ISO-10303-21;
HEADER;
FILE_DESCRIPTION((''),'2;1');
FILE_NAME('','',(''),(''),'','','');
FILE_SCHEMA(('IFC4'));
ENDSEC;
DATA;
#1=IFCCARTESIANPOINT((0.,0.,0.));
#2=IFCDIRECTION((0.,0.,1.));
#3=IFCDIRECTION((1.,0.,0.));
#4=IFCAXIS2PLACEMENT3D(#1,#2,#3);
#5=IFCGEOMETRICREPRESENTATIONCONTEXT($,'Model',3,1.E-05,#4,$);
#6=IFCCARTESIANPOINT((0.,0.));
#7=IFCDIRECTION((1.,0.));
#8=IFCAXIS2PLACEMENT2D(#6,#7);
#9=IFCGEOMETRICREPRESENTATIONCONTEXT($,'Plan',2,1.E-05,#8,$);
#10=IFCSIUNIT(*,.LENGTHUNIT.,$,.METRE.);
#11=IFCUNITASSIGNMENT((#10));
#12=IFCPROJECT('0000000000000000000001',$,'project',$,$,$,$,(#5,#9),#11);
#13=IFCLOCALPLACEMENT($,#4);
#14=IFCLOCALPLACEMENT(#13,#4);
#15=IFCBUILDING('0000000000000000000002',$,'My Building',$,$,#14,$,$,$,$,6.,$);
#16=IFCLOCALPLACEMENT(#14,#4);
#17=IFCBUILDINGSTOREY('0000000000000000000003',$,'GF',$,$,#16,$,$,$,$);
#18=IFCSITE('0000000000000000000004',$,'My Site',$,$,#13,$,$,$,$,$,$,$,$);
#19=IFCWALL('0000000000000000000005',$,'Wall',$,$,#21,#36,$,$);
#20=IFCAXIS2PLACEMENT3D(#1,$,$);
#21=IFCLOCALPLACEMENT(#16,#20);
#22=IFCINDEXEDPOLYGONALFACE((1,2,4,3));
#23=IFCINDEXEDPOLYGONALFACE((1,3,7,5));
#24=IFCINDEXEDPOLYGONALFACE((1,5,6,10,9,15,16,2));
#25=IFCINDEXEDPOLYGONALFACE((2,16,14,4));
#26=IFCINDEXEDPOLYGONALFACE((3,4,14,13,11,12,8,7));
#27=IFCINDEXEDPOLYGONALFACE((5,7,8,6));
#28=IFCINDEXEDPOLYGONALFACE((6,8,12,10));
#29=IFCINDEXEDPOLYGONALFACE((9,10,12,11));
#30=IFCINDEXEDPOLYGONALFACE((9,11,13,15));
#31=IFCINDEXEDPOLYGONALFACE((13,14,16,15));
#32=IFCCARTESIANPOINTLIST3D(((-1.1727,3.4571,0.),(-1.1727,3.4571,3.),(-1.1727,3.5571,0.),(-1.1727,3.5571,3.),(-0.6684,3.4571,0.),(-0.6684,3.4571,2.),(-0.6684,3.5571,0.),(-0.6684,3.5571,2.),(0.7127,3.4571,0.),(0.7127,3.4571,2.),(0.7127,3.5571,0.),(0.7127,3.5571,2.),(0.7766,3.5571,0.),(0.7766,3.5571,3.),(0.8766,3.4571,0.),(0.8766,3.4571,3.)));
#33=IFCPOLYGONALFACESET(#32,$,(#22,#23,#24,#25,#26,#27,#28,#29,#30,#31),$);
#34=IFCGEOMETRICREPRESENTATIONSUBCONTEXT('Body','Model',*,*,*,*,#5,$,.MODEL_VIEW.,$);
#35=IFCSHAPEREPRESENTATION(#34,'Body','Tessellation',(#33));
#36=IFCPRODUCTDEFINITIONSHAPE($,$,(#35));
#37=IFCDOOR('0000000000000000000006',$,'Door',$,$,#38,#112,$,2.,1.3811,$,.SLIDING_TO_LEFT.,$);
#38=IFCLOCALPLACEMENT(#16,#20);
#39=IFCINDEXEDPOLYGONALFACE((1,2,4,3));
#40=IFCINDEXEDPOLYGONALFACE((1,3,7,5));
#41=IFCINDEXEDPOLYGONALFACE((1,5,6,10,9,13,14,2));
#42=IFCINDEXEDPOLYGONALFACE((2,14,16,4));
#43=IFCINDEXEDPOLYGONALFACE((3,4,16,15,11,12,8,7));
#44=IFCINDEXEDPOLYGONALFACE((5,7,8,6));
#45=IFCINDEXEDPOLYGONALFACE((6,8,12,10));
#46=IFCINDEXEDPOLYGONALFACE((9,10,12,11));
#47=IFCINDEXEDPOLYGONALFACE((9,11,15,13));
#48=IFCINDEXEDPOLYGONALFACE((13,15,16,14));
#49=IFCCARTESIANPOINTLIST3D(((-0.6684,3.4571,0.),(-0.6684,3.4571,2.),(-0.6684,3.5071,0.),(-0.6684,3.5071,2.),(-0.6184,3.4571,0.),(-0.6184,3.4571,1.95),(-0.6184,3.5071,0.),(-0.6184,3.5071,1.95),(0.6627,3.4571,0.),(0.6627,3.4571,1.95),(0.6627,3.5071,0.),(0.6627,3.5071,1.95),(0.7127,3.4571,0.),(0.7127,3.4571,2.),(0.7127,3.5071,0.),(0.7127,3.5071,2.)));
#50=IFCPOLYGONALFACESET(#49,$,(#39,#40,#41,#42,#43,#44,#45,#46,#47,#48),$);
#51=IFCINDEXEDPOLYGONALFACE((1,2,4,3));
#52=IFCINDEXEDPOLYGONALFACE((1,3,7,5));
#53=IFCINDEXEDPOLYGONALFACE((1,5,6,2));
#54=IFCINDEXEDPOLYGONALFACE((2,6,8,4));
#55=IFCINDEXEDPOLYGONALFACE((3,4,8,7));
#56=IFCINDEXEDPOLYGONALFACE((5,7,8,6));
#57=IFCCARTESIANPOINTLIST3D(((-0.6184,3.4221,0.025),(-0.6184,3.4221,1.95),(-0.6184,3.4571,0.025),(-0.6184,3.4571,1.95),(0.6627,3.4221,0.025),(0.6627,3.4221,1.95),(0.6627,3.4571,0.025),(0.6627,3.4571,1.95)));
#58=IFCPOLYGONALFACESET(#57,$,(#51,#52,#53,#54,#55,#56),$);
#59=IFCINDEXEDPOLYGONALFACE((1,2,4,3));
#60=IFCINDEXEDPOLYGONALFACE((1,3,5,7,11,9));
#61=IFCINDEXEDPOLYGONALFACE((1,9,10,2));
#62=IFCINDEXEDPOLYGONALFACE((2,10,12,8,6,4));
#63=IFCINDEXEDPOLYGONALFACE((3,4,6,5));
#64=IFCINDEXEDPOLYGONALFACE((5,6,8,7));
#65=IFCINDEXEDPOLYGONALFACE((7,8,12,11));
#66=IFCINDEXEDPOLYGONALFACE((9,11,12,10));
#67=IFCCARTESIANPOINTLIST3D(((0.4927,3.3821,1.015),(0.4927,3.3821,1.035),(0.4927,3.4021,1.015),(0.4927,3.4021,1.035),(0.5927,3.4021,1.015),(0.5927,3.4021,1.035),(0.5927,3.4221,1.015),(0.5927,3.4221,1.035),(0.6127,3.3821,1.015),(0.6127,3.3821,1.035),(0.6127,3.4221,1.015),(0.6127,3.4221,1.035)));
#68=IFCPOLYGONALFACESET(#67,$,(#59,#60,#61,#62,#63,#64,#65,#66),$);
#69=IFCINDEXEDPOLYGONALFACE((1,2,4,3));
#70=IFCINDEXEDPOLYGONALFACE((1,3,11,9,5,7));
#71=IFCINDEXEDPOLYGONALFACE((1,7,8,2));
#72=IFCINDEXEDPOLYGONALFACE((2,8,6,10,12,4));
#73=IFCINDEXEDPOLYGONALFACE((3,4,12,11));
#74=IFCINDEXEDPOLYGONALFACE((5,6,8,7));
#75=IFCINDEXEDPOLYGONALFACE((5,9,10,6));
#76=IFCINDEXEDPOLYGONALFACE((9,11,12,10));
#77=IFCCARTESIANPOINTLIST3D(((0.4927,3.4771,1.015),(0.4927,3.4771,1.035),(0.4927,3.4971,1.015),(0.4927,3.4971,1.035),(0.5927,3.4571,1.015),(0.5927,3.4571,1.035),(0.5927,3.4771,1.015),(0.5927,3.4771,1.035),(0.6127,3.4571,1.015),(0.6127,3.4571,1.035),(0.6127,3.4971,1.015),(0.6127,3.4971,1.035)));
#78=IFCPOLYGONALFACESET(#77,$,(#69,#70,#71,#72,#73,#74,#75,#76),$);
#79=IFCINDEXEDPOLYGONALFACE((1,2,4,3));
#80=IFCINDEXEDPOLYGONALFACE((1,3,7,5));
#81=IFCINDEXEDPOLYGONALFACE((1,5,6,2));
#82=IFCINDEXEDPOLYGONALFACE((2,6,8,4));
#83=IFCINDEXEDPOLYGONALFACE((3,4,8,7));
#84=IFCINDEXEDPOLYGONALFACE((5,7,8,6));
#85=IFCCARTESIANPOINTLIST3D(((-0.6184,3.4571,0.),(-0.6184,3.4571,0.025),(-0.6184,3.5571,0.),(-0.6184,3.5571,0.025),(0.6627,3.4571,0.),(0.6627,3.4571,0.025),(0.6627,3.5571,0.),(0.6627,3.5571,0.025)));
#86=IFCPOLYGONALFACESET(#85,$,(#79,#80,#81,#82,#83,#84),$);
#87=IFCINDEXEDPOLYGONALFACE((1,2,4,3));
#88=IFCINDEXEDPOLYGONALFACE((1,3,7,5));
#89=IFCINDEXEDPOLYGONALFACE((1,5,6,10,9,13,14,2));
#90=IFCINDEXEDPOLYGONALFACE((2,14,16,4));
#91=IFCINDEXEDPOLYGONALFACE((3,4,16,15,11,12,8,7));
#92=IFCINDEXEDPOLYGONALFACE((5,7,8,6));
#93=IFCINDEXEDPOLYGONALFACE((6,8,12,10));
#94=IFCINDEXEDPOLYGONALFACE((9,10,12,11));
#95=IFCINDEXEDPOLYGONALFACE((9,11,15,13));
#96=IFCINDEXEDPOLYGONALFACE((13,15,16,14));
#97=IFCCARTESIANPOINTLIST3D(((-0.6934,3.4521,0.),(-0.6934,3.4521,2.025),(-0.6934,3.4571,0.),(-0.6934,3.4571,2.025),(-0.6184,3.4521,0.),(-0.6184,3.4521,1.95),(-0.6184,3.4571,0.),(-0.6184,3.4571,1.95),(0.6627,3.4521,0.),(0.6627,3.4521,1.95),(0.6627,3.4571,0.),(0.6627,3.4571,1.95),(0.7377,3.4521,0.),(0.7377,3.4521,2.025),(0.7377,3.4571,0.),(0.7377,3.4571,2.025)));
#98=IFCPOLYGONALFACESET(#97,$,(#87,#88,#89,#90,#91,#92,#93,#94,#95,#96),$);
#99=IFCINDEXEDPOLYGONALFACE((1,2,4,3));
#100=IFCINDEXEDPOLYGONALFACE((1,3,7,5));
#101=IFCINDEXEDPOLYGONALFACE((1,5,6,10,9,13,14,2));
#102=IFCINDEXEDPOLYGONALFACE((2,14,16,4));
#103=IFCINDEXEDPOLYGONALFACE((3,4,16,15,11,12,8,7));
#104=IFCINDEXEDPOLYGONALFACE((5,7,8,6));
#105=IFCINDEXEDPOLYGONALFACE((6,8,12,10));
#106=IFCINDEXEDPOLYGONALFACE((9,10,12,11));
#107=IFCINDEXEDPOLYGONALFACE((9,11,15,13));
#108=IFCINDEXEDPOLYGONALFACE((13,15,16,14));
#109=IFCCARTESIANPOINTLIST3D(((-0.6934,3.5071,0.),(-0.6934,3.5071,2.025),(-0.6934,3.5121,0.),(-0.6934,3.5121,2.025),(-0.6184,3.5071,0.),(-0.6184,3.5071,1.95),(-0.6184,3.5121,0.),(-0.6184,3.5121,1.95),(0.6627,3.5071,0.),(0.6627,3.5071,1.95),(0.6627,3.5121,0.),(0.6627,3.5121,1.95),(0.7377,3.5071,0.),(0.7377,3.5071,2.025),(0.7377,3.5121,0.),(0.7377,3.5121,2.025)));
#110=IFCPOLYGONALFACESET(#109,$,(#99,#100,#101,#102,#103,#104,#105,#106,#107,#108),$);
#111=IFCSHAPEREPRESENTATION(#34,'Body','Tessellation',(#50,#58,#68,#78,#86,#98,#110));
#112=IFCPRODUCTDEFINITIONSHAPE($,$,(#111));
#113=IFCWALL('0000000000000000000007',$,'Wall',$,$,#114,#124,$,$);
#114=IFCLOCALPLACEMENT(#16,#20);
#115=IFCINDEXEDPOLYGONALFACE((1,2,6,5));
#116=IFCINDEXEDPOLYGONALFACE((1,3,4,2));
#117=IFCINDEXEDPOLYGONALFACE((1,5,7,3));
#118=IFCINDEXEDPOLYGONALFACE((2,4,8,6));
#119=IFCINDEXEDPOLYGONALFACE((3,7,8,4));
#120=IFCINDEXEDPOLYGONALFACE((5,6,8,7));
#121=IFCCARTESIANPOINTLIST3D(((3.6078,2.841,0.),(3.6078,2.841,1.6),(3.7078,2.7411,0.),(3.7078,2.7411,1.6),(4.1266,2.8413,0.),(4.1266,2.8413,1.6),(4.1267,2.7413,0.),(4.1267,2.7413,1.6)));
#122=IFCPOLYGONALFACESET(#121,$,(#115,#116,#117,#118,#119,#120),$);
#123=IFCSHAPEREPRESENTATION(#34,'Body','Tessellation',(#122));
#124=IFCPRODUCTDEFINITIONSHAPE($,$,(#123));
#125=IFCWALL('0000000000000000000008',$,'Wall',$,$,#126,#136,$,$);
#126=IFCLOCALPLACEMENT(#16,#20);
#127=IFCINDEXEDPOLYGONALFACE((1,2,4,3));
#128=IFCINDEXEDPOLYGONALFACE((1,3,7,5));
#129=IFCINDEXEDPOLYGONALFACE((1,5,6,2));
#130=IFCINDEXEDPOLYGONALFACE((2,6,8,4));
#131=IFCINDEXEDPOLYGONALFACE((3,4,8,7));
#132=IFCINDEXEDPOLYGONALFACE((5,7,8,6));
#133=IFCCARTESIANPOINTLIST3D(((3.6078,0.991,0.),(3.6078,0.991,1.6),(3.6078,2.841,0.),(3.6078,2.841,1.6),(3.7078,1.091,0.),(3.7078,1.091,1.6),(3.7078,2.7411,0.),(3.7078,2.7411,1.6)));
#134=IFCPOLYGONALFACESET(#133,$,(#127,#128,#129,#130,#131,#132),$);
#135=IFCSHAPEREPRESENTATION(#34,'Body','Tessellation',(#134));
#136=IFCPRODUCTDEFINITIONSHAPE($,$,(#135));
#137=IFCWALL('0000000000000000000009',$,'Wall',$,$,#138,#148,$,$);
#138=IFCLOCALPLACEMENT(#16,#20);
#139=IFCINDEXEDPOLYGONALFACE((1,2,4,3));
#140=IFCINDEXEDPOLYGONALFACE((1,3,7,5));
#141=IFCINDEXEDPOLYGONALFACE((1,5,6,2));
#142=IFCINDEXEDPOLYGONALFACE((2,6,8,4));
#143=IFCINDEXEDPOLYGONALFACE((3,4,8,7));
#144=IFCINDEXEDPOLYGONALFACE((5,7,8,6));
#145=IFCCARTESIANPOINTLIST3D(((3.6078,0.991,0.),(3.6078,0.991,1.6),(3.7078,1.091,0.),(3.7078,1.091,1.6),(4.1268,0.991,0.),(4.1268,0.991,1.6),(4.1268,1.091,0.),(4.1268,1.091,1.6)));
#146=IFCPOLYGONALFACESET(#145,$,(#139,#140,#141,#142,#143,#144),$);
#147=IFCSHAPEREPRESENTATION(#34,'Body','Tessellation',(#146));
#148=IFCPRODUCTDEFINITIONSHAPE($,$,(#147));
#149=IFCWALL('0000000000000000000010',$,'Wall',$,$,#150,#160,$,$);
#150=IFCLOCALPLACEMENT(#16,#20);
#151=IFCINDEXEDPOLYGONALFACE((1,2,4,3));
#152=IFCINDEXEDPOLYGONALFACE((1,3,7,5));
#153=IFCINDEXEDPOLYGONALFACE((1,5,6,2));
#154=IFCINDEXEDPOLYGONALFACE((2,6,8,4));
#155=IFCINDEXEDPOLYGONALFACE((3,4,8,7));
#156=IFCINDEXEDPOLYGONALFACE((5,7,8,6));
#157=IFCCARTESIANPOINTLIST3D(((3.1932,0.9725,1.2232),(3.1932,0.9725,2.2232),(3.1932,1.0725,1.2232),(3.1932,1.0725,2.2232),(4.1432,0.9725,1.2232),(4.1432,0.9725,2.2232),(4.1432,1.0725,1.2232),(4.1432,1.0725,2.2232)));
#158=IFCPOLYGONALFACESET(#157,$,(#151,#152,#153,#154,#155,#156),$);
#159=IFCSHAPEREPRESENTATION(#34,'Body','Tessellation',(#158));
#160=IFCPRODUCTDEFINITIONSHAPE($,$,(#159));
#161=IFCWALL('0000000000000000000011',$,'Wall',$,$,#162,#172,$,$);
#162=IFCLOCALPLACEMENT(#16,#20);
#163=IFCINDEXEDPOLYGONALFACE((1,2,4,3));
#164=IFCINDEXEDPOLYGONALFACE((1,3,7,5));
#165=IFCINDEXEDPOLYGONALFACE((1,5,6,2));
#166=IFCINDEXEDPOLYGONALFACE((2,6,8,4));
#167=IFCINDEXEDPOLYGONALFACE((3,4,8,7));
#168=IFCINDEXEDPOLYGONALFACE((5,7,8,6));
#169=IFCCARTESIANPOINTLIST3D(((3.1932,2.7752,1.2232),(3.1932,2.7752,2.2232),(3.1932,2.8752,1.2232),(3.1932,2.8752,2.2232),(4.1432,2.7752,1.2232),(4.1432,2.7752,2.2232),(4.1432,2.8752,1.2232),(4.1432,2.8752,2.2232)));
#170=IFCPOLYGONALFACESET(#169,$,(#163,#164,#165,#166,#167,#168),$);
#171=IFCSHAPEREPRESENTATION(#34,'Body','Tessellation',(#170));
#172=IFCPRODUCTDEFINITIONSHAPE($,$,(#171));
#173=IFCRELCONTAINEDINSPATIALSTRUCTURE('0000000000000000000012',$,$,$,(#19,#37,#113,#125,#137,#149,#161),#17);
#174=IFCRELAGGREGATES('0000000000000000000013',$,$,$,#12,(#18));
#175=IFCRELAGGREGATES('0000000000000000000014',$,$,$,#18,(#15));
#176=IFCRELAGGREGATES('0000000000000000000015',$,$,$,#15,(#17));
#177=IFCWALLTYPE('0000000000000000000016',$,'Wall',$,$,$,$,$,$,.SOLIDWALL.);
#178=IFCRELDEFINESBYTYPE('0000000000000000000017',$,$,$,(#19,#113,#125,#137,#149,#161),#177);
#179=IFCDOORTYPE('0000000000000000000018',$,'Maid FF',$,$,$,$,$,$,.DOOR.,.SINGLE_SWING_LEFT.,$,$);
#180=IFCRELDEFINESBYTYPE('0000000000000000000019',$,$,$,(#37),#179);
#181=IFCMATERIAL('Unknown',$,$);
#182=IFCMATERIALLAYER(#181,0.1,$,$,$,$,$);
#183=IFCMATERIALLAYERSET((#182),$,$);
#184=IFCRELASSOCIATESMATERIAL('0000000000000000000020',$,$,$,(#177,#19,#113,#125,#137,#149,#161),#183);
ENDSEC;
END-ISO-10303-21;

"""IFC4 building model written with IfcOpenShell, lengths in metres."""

from ifc_helpers import new_model, entity, si_unit, frame, origin_with_axes, origin_2d_with_axis, place, context, subcontext, project, spatial, line, indexed_curve, outline, extrude, shape, source, transform, mapped, material, layer, layer_set, layer_usage, type_object, type_shapes, element, fill, save


model = new_model("IFC4")

# Units and contexts
model_context = context("Model", 3, precision=1e-05, world=origin_with_axes())
plan_context = context("Plan", 2, precision=1e-05, world=origin_2d_with_axis())
body_context_1 = subcontext(model_context, "Body", "Model", "MODEL_VIEW")
body_context_2 = subcontext(plan_context, "Body", "Plan", "PLAN_VIEW")
ifc_project = project(units=[si_unit("LENGTHUNIT", "METRE")], contexts=[model_context, plan_context])

# Site, building, storey
site_placement = place(None, origin_with_axes())
site = spatial("IfcSite", under=ifc_project, at=site_placement, Name="My Site")
building_placement = place(site_placement, origin_with_axes())
building = spatial("IfcBuilding", under=site, at=building_placement, Name="My Building", ElevationOfTerrain=6.0)
storey_placement = place(building_placement, origin_with_axes())
storey = spatial("IfcBuildingStorey", under=building, at=storey_placement, Name="GF")

# Shared definitions
ifc_material = material(Name="Unknown")
ifc_layer = layer(ifc_material, 0.1)
ifc_layer_set = layer_set([ifc_layer])
wall_type = type_object("IfcWallType", Name="Wall", PredefinedType="SOLIDWALL", material=ifc_layer_set)

# Wall, opening, door
ifc_layer_usage_1 = layer_usage(ifc_layer_set, "AXIS2", "POSITIVE", 0.0)
wall_1_placement = place(storey_placement, frame((0.7766, 3.5571, 0.0), z_axis=(0.0, 0.0, 1.0), x_axis=(-1.0, 0.0, 0.0)))
wall_1 = element("IfcWall", 1, at=wall_1_placement, inside=storey, type_object=wall_type, material=ifc_layer_usage_1, Name="Wall", context=body_context_1, shape_type="SweptSolid", body=[
    extrude(outline(indexed_curve([(0.0, 0.0), (-0.1, 0.1), (1.9493, 0.1), (1.9493, 0.0)], segments=[line(1, 2, 3, 4, 1)])), origin_with_axes(), (0.0, 0.0, 1.0), 3.0),
])
shared_shape_1 = source(origin_with_axes(), body_context_1, "Body", "SweptSolid", [
    extrude(outline(indexed_curve([(0.0, 0.0), (1.3811, 0.0), (1.3811, 2.0), (0.0, 2.0)], segments=[line(1, 2, 3, 4, 1)])), frame((0.0, -0.6, 0.0), z_axis=(0.0, -1.0, 0.0), x_axis=(1.0, 0.0, 0.0)), (0.0, 0.0, -1.0), 1.2),
])
opening_1_placement = place(wall_1_placement, frame((1.445, 0.1, 0.0), z_axis=(0.0, 0.0, 1.0), x_axis=(-1.0, 0.000001, 0.0)))
opening_1 = element("IfcOpeningElement", 2, at=opening_1_placement, cuts=wall_1, PredefinedType="OPENING", context=body_context_1, shape_type="MappedRepresentation", body=[
    mapped(shared_shape_1, transform((0.0, 0.0, 0.0), x_axis=(1.0, 0.0, 0.0), y_axis=(0.0, 1.0, 0.0), z_axis=(0.0, 0.0, 1.0), scale=1.0)),
])
door_type_1 = type_object("IfcDoorType", Name="Maid FF", OperationType="SINGLE_SWING_LEFT", PredefinedType="DOOR")
shared_shape_2 = source(origin_with_axes(), body_context_1, "Body", "SweptSolid", [
    extrude(outline(indexed_curve([(0.0, 0.0), (0.0, 2.0), (1.3811, 2.0), (1.3811, 0.0), (1.3311, 0.0), (1.3311, 1.95), (0.05, 1.95), (0.05, 0.0)], segments=[line(1, 2, 3, 4, 5, 6, 7, 8, 1)])), frame((0.0, 0.0, 0.0), z_axis=(0.0, -1.0, 0.0), x_axis=(1.0, 0.0, 0.0)), (0.0, 0.0, -1.0), 0.05),
    extrude(outline(indexed_curve([(0.0, 0.0), (1.2811, 0.0), (1.2811, 0.035), (0.0, 0.035)], segments=[line(1, 2, 3, 4, 1)])), frame((0.05, -0.035, 0.025), z_axis=(0.0, 0.0, 1.0), x_axis=(1.0, 0.0, 0.0)), (0.0, 0.0, 1.0), 1.925),
    extrude(outline(indexed_curve([(0.0, 0.0), (0.0, -0.04), (-0.12, -0.04), (-0.12, -0.02), (-0.02, -0.02), (-0.02, 0.0)], segments=[line(1, 2, 3, 4, 5, 6, 1)])), frame((1.2811, -0.035, 1.015), z_axis=(0.0, 0.0, 1.0), x_axis=(1.0, 0.0, 0.0)), (0.0, 0.0, 1.0), 0.02),
    extrude(outline(indexed_curve([(0.0, 0.0), (0.0, 0.04), (-0.12, 0.04), (-0.12, 0.02), (-0.02, 0.02), (-0.02, 0.0)], segments=[line(1, 2, 3, 4, 5, 6, 1)])), frame((1.2811, 0.0, 1.015), z_axis=(0.0, 0.0, 1.0), x_axis=(1.0, 0.0, 0.0)), (0.0, 0.0, 1.0), 0.02),
    extrude(outline(indexed_curve([(0.0, 0.0), (1.2811, 0.0), (1.2811, 0.1), (0.0, 0.1)], segments=[line(1, 2, 3, 4, 1)])), frame((0.05, 0.0, 0.0), z_axis=(0.0, 0.0, 1.0), x_axis=(1.0, 0.0, 0.0)), (0.0, 0.0, 1.0), 0.025),
    extrude(outline(indexed_curve([(0.0, 0.0), (0.0, 2.025), (1.4311, 2.025), (1.4311, 0.0), (1.3561, 0.0), (1.3561, 1.95), (0.075, 1.95), (0.075, 0.0)], segments=[line(1, 2, 3, 4, 5, 6, 7, 8, 1)])), frame((-0.025, -0.005, 0.0), z_axis=(0.0, -1.0, 0.0), x_axis=(1.0, 0.0, 0.0)), (0.0, 0.0, -1.0), 0.005),
    extrude(outline(indexed_curve([(0.0, 0.0), (0.0, 2.025), (1.4311, 2.025), (1.4311, 0.0), (1.3561, 0.0), (1.3561, 1.95), (0.075, 1.95), (0.075, 0.0)], segments=[line(1, 2, 3, 4, 5, 6, 7, 8, 1)])), frame((-0.025, 0.05, 0.0), z_axis=(0.0, -1.0, 0.0), x_axis=(1.0, 0.0, 0.0)), (0.0, 0.0, -1.0), 0.005),
])
shared_shape_3 = source(origin_with_axes(), body_context_2, "Body", "Curve2D", [
    entity("IfcIndexedPolyCurve", entity("IfcCartesianPointList2D", [[0.0, 0.0], [0.05, 0.0], [0.05, 0.05], [0.0, 0.05]]), [entity("IfcLineIndex", [1, 2, 3, 4, 1])]),
    entity("IfcIndexedPolyCurve", entity("IfcCartesianPointList2D", [[1.3811, 0.0], [1.3311, 0.0], [1.3311, 0.05], [1.3811, 0.05]]), [entity("IfcLineIndex", [1, 2, 3, 4, 1])]),
    entity("IfcIndexedPolyCurve", entity("IfcCartesianPointList2D", [[-0.5906, -0.035], [0.6906, -0.035], [0.6906, 0.0], [-0.5906, 0.0]]), [entity("IfcLineIndex", [1, 2, 3, 4, 1])]),
])
type_shapes(door_type_1, [shared_shape_2, shared_shape_3])
door_1_placement = place(opening_1_placement, frame((0.0, 0.0, 0.0), z_axis=(0.0, 0.0, 1.0), x_axis=(1.0, 0.0, 0.0)))
door_1 = element("IfcDoor", 3, at=door_1_placement, inside=storey, type_object=door_type_1, Name="Door", OperationType="SLIDING_TO_LEFT", OverallHeight=2.0, OverallWidth=1.3811, shapes=[
    shape(body_context_1, "Body", "MappedRepresentation", [mapped(shared_shape_2, transform((0.0, 0.0, 0.0), x_axis=(1.0, 0.0, 0.0), y_axis=(0.0, 1.0, 0.0), z_axis=(0.0, 0.0, 1.0), scale=1.0))]),
    shape(body_context_2, "Body", "MappedRepresentation", [mapped(shared_shape_3, transform((0.0, 0.0, 0.0), x_axis=(1.0, 0.0, 0.0), y_axis=(0.0, 1.0, 0.0), z_axis=(0.0, 0.0, 1.0), scale=1.0))]),
])
fill(opening_1, door_1)

# Walls
ifc_layer_usage_2 = layer_usage(ifc_layer_set, "AXIS2", "POSITIVE", 0.0)
wall_2_placement = place(storey_placement, frame((4.1266, 2.8413, 0.0), z_axis=(0.0, 0.0, 1.0), x_axis=(-1.0, -0.000506, 0.0)))
element("IfcWall", 4, at=wall_2_placement, inside=storey, type_object=wall_type, material=ifc_layer_usage_2, Name="Wall", context=body_context_1, shape_type="SweptSolid", body=[
    extrude(outline(indexed_curve([(0.0, 0.0), (0.0, 0.1), (0.4189, 0.1), (0.5188, 0.0)], segments=[line(1, 2, 3, 4, 1)])), origin_with_axes(), (0.0, 0.0, 1.0), 1.6),
])
ifc_layer_usage_3 = layer_usage(ifc_layer_set, "AXIS2", "POSITIVE", 0.0)
wall_3_placement = place(storey_placement, frame((3.6078, 2.841, 0.0), z_axis=(0.0, 0.0, 1.0), x_axis=(0.0, -1.0, 0.0)))
element("IfcWall", 5, at=wall_3_placement, inside=storey, type_object=wall_type, material=ifc_layer_usage_3, Name="Wall", context=body_context_1, shape_type="SweptSolid", body=[
    extrude(outline(indexed_curve([(0.0, 0.0), (0.0999, 0.1), (1.75, 0.1), (1.85, 0.0)], segments=[line(1, 2, 3, 4, 1)])), origin_with_axes(), (0.0, 0.0, 1.0), 1.6),
])
ifc_layer_usage_4 = layer_usage(ifc_layer_set, "AXIS2", "POSITIVE", 0.0)
wall_4_placement = place(storey_placement, frame((3.6078, 0.991, 0.0), z_axis=(0.0, 0.0, 1.0), x_axis=(1.0, 0.0, 0.0)))
element("IfcWall", 6, at=wall_4_placement, inside=storey, type_object=wall_type, material=ifc_layer_usage_4, Name="Wall", context=body_context_1, shape_type="SweptSolid", body=[
    extrude(outline(indexed_curve([(0.0, 0.0), (0.1, 0.1), (0.519, 0.1), (0.519, 0.0)], segments=[line(1, 2, 3, 4, 1)])), origin_with_axes(), (0.0, 0.0, 1.0), 1.6),
])
ifc_layer_usage_5 = layer_usage(ifc_layer_set, "AXIS2", "POSITIVE", 0.0)
wall_5_placement = place(storey_placement, frame((3.1932, 0.9725, 1.2232), z_axis=(0.0, 0.0, 1.0), x_axis=(1.0, 0.0, 0.0)))
element("IfcWall", 7, at=wall_5_placement, inside=storey, type_object=wall_type, material=ifc_layer_usage_5, Name="Wall", context=body_context_1, shape_type="SweptSolid", body=[
    extrude(outline(indexed_curve([(0.0, 0.0), (0.0, 0.1), (0.95, 0.1), (0.95, 0.0)], segments=[line(1, 2, 3, 4, 1)])), origin_with_axes(), (0.0, 0.0, 1.0), 1.0),
])
ifc_layer_usage_6 = layer_usage(ifc_layer_set, "AXIS2", "POSITIVE", 0.0)
wall_6_placement = place(storey_placement, frame((3.1932, 2.7752, 1.2232), z_axis=(0.0, 0.0, 1.0), x_axis=(1.0, 0.0, 0.0)))
element("IfcWall", 8, at=wall_6_placement, inside=storey, type_object=wall_type, material=ifc_layer_usage_6, Name="Wall", context=body_context_1, shape_type="SweptSolid", body=[
    extrude(outline(indexed_curve([(0.0, 0.0), (0.0, 0.1), (0.95, 0.1), (0.95, 0.0)], segments=[line(1, 2, 3, 4, 1)])), origin_with_axes(), (0.0, 0.0, 1.0), 1.0),
])

save(model, "model.ifc")
